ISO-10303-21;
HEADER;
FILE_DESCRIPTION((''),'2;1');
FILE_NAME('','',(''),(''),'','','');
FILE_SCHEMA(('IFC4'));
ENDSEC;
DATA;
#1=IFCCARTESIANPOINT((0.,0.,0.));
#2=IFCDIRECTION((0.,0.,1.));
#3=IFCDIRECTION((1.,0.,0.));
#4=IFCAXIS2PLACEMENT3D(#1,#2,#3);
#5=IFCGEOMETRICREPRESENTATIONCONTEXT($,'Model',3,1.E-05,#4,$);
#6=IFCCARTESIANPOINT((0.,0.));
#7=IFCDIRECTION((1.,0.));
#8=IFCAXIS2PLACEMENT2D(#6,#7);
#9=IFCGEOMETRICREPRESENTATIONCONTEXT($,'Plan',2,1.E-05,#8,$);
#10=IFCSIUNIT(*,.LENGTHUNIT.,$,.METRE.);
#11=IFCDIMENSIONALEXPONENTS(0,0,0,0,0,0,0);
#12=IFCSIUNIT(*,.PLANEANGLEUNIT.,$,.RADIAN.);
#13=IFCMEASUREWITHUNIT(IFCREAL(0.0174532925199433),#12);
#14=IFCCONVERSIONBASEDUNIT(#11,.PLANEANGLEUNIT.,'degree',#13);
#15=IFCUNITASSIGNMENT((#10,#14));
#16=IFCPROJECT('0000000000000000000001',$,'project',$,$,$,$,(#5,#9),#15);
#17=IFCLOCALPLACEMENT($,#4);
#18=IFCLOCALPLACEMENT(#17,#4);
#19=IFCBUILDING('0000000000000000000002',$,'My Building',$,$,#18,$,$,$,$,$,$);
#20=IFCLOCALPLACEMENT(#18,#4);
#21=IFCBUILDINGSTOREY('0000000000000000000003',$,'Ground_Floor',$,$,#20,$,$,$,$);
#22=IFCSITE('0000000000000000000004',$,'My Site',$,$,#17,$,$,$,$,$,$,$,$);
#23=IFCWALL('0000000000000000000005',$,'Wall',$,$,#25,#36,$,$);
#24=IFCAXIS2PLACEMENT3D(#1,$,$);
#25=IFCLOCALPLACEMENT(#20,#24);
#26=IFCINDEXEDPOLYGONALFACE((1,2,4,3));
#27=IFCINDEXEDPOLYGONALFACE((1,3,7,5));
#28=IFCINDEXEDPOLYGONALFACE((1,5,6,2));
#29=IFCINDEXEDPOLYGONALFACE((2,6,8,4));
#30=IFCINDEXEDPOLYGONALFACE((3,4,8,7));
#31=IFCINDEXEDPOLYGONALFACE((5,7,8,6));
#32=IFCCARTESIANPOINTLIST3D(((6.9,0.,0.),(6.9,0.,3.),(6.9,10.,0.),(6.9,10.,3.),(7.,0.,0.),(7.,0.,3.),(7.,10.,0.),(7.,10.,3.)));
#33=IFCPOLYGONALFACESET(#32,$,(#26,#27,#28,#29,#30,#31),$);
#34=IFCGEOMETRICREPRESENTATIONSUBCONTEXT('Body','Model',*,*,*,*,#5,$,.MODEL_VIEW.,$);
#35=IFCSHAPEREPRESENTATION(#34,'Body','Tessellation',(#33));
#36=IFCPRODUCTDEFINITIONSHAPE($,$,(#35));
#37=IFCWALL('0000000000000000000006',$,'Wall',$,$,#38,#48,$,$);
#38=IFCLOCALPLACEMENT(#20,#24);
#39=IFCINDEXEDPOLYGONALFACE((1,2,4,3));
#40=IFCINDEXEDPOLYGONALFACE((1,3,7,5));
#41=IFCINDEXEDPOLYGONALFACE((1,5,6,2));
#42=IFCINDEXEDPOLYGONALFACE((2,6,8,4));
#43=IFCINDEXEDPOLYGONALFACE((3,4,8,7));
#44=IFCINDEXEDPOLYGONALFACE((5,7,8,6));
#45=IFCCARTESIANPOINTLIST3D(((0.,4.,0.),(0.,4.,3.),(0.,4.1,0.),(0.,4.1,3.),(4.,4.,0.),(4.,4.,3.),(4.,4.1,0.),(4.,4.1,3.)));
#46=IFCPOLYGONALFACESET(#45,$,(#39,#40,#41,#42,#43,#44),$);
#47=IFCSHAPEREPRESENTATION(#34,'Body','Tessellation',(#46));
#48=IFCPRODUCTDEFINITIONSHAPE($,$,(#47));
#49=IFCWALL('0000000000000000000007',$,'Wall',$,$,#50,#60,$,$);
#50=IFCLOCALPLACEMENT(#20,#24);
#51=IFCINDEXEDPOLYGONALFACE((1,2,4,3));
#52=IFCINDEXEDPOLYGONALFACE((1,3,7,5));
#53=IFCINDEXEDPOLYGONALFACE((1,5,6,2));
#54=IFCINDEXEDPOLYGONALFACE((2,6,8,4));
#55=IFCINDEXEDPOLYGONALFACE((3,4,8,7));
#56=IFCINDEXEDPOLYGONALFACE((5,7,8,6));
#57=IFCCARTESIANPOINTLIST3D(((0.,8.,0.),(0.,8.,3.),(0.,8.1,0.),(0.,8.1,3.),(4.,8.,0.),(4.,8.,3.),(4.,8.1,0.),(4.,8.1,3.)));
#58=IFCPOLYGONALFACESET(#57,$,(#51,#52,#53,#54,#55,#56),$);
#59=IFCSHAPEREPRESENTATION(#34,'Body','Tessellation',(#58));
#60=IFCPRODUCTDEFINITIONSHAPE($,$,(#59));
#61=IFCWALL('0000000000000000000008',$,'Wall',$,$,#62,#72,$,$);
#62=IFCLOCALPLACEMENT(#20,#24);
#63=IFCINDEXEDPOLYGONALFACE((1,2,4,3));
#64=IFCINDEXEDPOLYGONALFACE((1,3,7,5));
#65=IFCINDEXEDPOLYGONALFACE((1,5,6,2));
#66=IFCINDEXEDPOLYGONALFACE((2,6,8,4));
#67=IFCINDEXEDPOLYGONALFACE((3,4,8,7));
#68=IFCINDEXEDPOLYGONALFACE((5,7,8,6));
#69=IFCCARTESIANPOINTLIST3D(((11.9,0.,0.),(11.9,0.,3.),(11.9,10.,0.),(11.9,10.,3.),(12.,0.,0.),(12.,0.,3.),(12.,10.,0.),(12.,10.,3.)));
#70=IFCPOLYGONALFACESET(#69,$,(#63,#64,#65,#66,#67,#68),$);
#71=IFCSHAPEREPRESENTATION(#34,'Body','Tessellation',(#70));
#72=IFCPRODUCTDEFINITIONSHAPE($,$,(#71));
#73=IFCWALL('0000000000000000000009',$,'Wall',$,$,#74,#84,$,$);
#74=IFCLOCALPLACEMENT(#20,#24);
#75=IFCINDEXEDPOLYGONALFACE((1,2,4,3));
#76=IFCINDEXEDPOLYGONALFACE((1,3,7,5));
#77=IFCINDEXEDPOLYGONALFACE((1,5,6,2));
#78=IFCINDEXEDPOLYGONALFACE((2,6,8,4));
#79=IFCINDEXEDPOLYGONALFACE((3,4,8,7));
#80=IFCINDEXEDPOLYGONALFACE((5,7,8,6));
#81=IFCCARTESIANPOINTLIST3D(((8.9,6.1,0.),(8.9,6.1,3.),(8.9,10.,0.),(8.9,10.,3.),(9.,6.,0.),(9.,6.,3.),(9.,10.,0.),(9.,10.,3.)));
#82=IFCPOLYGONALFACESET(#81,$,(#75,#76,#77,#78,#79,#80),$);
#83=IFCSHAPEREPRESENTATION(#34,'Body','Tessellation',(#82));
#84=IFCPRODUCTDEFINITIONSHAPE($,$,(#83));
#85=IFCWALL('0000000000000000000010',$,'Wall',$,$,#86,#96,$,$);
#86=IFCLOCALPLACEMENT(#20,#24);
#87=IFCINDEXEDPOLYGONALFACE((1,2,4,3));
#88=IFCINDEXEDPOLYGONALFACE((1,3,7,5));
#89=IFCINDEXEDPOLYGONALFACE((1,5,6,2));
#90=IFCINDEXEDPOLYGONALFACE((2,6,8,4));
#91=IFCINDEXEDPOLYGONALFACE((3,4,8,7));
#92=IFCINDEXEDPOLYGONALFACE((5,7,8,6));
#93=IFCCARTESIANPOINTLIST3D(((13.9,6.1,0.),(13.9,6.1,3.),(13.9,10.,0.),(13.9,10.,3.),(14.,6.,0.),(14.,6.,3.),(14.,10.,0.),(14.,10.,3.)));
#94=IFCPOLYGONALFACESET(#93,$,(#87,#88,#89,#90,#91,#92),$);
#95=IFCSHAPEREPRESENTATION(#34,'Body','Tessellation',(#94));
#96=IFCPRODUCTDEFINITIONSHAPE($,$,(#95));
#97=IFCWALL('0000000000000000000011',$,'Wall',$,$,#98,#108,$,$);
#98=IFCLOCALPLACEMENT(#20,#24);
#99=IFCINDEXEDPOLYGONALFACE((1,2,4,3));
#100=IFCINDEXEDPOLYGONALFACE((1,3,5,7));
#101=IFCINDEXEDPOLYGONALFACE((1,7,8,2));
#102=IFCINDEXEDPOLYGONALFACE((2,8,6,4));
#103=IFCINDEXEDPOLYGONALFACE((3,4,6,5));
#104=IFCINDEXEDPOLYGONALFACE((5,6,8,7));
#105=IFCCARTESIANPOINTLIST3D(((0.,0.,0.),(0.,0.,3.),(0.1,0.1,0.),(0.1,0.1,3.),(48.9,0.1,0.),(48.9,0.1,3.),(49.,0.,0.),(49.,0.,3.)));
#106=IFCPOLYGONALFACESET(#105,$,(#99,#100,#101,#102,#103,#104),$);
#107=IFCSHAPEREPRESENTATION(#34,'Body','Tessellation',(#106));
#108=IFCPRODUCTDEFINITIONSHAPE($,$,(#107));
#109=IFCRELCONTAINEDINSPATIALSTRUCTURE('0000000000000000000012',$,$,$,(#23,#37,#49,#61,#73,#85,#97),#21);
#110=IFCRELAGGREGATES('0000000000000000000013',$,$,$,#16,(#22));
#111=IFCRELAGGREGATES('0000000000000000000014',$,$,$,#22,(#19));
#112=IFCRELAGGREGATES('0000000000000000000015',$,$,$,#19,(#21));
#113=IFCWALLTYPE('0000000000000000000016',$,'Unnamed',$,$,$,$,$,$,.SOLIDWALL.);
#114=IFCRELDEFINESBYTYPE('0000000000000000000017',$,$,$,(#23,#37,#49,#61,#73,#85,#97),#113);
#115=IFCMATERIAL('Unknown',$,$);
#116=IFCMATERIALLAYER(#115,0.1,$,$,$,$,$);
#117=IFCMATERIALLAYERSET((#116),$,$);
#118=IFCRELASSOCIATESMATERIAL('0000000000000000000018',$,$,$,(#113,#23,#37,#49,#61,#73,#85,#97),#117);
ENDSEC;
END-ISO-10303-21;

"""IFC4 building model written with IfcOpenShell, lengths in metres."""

from ifc_helpers import new_model, entity, si_unit, converted_unit, frame, origin_with_axes, origin_2d_with_axis, place, context, subcontext, project, spatial, line, indexed_curve, outline, extrude, material, layer, layer_set, layer_usage, type_object, element, save


model = new_model("IFC4")

# Units and contexts
model_context = context("Model", 3, precision=1e-05, world=origin_with_axes())
plan_context = context("Plan", 2, precision=1e-05, world=origin_2d_with_axis())
body_context_1 = subcontext(model_context, "Body", "Model", "MODEL_VIEW")
ifc_project = project(units=[si_unit("LENGTHUNIT", "METRE"), converted_unit("PLANEANGLEUNIT", "degree", entity("IfcReal", 0.0174532925199433), si_unit("PLANEANGLEUNIT", "RADIAN"), dimensions=[0, 0, 0, 0, 0, 0, 0])], contexts=[model_context, plan_context])

# Site, building, storey
site_placement = place(None, origin_with_axes())
site = spatial("IfcSite", under=ifc_project, at=site_placement, Name="My Site")
building_placement = place(site_placement, origin_with_axes())
building = spatial("IfcBuilding", under=site, at=building_placement, Name="My Building")
storey_placement = place(building_placement, origin_with_axes())
storey = spatial("IfcBuildingStorey", under=building, at=storey_placement, Name="Ground_Floor")

# Shared definitions
ifc_material = material(Name="Unknown")
ifc_layer = layer(ifc_material, 0.1)
ifc_layer_set = layer_set([ifc_layer])
wall_type = type_object("IfcWallType", Name="Unnamed", PredefinedType="SOLIDWALL", material=ifc_layer_set)

# Walls
ifc_layer_usage_1 = layer_usage(ifc_layer_set, "AXIS2", "POSITIVE", 0.0)
wall_1_placement = place(storey_placement, frame((7.0, 0.0, 0.0), z_axis=(0.0, 0.0, 1.0), x_axis=(0.0, 1.0, 0.0)))
element("IfcWall", 1, at=wall_1_placement, inside=storey, type_object=wall_type, material=ifc_layer_usage_1, Name="Wall", context=body_context_1, shape_type="SweptSolid", body=[
    extrude(outline(indexed_curve([(0.0, 0.0), (0.0, 0.1), (10.0, 0.1), (10.0, 0.0)], segments=[line(1, 2, 3, 4, 1)])), origin_with_axes(), (0.0, 0.0, 1.0), 3.0),
])
ifc_layer_usage_2 = layer_usage(ifc_layer_set, "AXIS2", "POSITIVE", 0.0)
wall_2_placement = place(storey_placement, frame((0.0, 4.0, 0.0), z_axis=(0.0, 0.0, 1.0), x_axis=(1.0, 0.0, 0.0)))
element("IfcWall", 2, at=wall_2_placement, inside=storey, type_object=wall_type, material=ifc_layer_usage_2, Name="Wall", context=body_context_1, shape_type="SweptSolid", body=[
    extrude(outline(indexed_curve([(0.0, 0.0), (0.0, 0.1), (4.0, 0.1), (4.0, 0.0)], segments=[line(1, 2, 3, 4, 1)])), origin_with_axes(), (0.0, 0.0, 1.0), 3.0),
])
ifc_layer_usage_3 = layer_usage(ifc_layer_set, "AXIS2", "POSITIVE", 0.0)
wall_3_placement = place(storey_placement, frame((0.0, 8.0, 0.0), z_axis=(0.0, 0.0, 1.0), x_axis=(1.0, 0.0, 0.0)))
element("IfcWall", 3, at=wall_3_placement, inside=storey, type_object=wall_type, material=ifc_layer_usage_3, Name="Wall", context=body_context_1, shape_type="SweptSolid", body=[
    extrude(outline(indexed_curve([(0.0, 0.0), (0.0, 0.1), (4.0, 0.1), (4.0, 0.0)], segments=[line(1, 2, 3, 4, 1)])), origin_with_axes(), (0.0, 0.0, 1.0), 3.0),
])
ifc_layer_usage_4 = layer_usage(ifc_layer_set, "AXIS2", "POSITIVE", 0.0)
wall_4_placement = place(storey_placement, frame((12.0, 0.0, 0.0), z_axis=(0.0, 0.0, 1.0), x_axis=(0.0, 1.0, 0.0)))
element("IfcWall", 4, at=wall_4_placement, inside=storey, type_object=wall_type, material=ifc_layer_usage_4, Name="Wall", context=body_context_1, shape_type="SweptSolid", body=[
    extrude(outline(indexed_curve([(0.0, 0.0), (0.0, 0.1), (10.0, 0.1), (10.0, 0.0)], segments=[line(1, 2, 3, 4, 1)])), origin_with_axes(), (0.0, 0.0, 1.0), 3.0),
])
ifc_layer_usage_5 = layer_usage(ifc_layer_set, "AXIS2", "POSITIVE", 0.0)
wall_5_placement = place(storey_placement, frame((9.0, 6.0, 0.0), z_axis=(0.0, 0.0, 1.0), x_axis=(0.0, 1.0, 0.0)))
element("IfcWall", 5, at=wall_5_placement, inside=storey, type_object=wall_type, material=ifc_layer_usage_5, Name="Wall", context=body_context_1, shape_type="SweptSolid", body=[
    extrude(outline(indexed_curve([(0.0, 0.0), (0.1, 0.1), (4.0, 0.1), (4.0, 0.0)], segments=[line(1, 2, 3, 4, 1)])), origin_with_axes(), (0.0, 0.0, 1.0), 3.0),
])
ifc_layer_usage_6 = layer_usage(ifc_layer_set, "AXIS2", "POSITIVE", 0.0)
wall_6_placement = place(storey_placement, frame((14.0, 6.0, 0.0), z_axis=(0.0, 0.0, 1.0), x_axis=(0.0, 1.0, 0.0)))
element("IfcWall", 6, at=wall_6_placement, inside=storey, type_object=wall_type, material=ifc_layer_usage_6, Name="Wall", context=body_context_1, shape_type="SweptSolid", body=[
    extrude(outline(indexed_curve([(0.0, 0.0), (0.1, 0.1), (4.0, 0.1), (4.0, 0.0)], segments=[line(1, 2, 3, 4, 1)])), origin_with_axes(), (0.0, 0.0, 1.0), 3.0),
])

# Wall
ifc_layer_usage_7 = layer_usage(ifc_layer_set, "AXIS2", "POSITIVE", 0.0)
wall_7_placement = place(storey_placement, frame((0.0, 0.0, 0.0), z_axis=(0.0, 0.0, 1.0), x_axis=(1.0, 0.0, 0.0)))
element("IfcWall", 7, at=wall_7_placement, inside=storey, type_object=wall_type, material=ifc_layer_usage_7, Name="Wall", context=body_context_1, shape_type="SweptSolid", body=[
    extrude(outline(indexed_curve([(0.0, 0.0), (0.1, 0.1), (48.9, 0.1), (49.0, 0.0)], segments=[line(1, 2, 3, 4, 1)])), origin_with_axes(), (0.0, 0.0, 1.0), 3.0),
])

save(model, "model.ifc")
